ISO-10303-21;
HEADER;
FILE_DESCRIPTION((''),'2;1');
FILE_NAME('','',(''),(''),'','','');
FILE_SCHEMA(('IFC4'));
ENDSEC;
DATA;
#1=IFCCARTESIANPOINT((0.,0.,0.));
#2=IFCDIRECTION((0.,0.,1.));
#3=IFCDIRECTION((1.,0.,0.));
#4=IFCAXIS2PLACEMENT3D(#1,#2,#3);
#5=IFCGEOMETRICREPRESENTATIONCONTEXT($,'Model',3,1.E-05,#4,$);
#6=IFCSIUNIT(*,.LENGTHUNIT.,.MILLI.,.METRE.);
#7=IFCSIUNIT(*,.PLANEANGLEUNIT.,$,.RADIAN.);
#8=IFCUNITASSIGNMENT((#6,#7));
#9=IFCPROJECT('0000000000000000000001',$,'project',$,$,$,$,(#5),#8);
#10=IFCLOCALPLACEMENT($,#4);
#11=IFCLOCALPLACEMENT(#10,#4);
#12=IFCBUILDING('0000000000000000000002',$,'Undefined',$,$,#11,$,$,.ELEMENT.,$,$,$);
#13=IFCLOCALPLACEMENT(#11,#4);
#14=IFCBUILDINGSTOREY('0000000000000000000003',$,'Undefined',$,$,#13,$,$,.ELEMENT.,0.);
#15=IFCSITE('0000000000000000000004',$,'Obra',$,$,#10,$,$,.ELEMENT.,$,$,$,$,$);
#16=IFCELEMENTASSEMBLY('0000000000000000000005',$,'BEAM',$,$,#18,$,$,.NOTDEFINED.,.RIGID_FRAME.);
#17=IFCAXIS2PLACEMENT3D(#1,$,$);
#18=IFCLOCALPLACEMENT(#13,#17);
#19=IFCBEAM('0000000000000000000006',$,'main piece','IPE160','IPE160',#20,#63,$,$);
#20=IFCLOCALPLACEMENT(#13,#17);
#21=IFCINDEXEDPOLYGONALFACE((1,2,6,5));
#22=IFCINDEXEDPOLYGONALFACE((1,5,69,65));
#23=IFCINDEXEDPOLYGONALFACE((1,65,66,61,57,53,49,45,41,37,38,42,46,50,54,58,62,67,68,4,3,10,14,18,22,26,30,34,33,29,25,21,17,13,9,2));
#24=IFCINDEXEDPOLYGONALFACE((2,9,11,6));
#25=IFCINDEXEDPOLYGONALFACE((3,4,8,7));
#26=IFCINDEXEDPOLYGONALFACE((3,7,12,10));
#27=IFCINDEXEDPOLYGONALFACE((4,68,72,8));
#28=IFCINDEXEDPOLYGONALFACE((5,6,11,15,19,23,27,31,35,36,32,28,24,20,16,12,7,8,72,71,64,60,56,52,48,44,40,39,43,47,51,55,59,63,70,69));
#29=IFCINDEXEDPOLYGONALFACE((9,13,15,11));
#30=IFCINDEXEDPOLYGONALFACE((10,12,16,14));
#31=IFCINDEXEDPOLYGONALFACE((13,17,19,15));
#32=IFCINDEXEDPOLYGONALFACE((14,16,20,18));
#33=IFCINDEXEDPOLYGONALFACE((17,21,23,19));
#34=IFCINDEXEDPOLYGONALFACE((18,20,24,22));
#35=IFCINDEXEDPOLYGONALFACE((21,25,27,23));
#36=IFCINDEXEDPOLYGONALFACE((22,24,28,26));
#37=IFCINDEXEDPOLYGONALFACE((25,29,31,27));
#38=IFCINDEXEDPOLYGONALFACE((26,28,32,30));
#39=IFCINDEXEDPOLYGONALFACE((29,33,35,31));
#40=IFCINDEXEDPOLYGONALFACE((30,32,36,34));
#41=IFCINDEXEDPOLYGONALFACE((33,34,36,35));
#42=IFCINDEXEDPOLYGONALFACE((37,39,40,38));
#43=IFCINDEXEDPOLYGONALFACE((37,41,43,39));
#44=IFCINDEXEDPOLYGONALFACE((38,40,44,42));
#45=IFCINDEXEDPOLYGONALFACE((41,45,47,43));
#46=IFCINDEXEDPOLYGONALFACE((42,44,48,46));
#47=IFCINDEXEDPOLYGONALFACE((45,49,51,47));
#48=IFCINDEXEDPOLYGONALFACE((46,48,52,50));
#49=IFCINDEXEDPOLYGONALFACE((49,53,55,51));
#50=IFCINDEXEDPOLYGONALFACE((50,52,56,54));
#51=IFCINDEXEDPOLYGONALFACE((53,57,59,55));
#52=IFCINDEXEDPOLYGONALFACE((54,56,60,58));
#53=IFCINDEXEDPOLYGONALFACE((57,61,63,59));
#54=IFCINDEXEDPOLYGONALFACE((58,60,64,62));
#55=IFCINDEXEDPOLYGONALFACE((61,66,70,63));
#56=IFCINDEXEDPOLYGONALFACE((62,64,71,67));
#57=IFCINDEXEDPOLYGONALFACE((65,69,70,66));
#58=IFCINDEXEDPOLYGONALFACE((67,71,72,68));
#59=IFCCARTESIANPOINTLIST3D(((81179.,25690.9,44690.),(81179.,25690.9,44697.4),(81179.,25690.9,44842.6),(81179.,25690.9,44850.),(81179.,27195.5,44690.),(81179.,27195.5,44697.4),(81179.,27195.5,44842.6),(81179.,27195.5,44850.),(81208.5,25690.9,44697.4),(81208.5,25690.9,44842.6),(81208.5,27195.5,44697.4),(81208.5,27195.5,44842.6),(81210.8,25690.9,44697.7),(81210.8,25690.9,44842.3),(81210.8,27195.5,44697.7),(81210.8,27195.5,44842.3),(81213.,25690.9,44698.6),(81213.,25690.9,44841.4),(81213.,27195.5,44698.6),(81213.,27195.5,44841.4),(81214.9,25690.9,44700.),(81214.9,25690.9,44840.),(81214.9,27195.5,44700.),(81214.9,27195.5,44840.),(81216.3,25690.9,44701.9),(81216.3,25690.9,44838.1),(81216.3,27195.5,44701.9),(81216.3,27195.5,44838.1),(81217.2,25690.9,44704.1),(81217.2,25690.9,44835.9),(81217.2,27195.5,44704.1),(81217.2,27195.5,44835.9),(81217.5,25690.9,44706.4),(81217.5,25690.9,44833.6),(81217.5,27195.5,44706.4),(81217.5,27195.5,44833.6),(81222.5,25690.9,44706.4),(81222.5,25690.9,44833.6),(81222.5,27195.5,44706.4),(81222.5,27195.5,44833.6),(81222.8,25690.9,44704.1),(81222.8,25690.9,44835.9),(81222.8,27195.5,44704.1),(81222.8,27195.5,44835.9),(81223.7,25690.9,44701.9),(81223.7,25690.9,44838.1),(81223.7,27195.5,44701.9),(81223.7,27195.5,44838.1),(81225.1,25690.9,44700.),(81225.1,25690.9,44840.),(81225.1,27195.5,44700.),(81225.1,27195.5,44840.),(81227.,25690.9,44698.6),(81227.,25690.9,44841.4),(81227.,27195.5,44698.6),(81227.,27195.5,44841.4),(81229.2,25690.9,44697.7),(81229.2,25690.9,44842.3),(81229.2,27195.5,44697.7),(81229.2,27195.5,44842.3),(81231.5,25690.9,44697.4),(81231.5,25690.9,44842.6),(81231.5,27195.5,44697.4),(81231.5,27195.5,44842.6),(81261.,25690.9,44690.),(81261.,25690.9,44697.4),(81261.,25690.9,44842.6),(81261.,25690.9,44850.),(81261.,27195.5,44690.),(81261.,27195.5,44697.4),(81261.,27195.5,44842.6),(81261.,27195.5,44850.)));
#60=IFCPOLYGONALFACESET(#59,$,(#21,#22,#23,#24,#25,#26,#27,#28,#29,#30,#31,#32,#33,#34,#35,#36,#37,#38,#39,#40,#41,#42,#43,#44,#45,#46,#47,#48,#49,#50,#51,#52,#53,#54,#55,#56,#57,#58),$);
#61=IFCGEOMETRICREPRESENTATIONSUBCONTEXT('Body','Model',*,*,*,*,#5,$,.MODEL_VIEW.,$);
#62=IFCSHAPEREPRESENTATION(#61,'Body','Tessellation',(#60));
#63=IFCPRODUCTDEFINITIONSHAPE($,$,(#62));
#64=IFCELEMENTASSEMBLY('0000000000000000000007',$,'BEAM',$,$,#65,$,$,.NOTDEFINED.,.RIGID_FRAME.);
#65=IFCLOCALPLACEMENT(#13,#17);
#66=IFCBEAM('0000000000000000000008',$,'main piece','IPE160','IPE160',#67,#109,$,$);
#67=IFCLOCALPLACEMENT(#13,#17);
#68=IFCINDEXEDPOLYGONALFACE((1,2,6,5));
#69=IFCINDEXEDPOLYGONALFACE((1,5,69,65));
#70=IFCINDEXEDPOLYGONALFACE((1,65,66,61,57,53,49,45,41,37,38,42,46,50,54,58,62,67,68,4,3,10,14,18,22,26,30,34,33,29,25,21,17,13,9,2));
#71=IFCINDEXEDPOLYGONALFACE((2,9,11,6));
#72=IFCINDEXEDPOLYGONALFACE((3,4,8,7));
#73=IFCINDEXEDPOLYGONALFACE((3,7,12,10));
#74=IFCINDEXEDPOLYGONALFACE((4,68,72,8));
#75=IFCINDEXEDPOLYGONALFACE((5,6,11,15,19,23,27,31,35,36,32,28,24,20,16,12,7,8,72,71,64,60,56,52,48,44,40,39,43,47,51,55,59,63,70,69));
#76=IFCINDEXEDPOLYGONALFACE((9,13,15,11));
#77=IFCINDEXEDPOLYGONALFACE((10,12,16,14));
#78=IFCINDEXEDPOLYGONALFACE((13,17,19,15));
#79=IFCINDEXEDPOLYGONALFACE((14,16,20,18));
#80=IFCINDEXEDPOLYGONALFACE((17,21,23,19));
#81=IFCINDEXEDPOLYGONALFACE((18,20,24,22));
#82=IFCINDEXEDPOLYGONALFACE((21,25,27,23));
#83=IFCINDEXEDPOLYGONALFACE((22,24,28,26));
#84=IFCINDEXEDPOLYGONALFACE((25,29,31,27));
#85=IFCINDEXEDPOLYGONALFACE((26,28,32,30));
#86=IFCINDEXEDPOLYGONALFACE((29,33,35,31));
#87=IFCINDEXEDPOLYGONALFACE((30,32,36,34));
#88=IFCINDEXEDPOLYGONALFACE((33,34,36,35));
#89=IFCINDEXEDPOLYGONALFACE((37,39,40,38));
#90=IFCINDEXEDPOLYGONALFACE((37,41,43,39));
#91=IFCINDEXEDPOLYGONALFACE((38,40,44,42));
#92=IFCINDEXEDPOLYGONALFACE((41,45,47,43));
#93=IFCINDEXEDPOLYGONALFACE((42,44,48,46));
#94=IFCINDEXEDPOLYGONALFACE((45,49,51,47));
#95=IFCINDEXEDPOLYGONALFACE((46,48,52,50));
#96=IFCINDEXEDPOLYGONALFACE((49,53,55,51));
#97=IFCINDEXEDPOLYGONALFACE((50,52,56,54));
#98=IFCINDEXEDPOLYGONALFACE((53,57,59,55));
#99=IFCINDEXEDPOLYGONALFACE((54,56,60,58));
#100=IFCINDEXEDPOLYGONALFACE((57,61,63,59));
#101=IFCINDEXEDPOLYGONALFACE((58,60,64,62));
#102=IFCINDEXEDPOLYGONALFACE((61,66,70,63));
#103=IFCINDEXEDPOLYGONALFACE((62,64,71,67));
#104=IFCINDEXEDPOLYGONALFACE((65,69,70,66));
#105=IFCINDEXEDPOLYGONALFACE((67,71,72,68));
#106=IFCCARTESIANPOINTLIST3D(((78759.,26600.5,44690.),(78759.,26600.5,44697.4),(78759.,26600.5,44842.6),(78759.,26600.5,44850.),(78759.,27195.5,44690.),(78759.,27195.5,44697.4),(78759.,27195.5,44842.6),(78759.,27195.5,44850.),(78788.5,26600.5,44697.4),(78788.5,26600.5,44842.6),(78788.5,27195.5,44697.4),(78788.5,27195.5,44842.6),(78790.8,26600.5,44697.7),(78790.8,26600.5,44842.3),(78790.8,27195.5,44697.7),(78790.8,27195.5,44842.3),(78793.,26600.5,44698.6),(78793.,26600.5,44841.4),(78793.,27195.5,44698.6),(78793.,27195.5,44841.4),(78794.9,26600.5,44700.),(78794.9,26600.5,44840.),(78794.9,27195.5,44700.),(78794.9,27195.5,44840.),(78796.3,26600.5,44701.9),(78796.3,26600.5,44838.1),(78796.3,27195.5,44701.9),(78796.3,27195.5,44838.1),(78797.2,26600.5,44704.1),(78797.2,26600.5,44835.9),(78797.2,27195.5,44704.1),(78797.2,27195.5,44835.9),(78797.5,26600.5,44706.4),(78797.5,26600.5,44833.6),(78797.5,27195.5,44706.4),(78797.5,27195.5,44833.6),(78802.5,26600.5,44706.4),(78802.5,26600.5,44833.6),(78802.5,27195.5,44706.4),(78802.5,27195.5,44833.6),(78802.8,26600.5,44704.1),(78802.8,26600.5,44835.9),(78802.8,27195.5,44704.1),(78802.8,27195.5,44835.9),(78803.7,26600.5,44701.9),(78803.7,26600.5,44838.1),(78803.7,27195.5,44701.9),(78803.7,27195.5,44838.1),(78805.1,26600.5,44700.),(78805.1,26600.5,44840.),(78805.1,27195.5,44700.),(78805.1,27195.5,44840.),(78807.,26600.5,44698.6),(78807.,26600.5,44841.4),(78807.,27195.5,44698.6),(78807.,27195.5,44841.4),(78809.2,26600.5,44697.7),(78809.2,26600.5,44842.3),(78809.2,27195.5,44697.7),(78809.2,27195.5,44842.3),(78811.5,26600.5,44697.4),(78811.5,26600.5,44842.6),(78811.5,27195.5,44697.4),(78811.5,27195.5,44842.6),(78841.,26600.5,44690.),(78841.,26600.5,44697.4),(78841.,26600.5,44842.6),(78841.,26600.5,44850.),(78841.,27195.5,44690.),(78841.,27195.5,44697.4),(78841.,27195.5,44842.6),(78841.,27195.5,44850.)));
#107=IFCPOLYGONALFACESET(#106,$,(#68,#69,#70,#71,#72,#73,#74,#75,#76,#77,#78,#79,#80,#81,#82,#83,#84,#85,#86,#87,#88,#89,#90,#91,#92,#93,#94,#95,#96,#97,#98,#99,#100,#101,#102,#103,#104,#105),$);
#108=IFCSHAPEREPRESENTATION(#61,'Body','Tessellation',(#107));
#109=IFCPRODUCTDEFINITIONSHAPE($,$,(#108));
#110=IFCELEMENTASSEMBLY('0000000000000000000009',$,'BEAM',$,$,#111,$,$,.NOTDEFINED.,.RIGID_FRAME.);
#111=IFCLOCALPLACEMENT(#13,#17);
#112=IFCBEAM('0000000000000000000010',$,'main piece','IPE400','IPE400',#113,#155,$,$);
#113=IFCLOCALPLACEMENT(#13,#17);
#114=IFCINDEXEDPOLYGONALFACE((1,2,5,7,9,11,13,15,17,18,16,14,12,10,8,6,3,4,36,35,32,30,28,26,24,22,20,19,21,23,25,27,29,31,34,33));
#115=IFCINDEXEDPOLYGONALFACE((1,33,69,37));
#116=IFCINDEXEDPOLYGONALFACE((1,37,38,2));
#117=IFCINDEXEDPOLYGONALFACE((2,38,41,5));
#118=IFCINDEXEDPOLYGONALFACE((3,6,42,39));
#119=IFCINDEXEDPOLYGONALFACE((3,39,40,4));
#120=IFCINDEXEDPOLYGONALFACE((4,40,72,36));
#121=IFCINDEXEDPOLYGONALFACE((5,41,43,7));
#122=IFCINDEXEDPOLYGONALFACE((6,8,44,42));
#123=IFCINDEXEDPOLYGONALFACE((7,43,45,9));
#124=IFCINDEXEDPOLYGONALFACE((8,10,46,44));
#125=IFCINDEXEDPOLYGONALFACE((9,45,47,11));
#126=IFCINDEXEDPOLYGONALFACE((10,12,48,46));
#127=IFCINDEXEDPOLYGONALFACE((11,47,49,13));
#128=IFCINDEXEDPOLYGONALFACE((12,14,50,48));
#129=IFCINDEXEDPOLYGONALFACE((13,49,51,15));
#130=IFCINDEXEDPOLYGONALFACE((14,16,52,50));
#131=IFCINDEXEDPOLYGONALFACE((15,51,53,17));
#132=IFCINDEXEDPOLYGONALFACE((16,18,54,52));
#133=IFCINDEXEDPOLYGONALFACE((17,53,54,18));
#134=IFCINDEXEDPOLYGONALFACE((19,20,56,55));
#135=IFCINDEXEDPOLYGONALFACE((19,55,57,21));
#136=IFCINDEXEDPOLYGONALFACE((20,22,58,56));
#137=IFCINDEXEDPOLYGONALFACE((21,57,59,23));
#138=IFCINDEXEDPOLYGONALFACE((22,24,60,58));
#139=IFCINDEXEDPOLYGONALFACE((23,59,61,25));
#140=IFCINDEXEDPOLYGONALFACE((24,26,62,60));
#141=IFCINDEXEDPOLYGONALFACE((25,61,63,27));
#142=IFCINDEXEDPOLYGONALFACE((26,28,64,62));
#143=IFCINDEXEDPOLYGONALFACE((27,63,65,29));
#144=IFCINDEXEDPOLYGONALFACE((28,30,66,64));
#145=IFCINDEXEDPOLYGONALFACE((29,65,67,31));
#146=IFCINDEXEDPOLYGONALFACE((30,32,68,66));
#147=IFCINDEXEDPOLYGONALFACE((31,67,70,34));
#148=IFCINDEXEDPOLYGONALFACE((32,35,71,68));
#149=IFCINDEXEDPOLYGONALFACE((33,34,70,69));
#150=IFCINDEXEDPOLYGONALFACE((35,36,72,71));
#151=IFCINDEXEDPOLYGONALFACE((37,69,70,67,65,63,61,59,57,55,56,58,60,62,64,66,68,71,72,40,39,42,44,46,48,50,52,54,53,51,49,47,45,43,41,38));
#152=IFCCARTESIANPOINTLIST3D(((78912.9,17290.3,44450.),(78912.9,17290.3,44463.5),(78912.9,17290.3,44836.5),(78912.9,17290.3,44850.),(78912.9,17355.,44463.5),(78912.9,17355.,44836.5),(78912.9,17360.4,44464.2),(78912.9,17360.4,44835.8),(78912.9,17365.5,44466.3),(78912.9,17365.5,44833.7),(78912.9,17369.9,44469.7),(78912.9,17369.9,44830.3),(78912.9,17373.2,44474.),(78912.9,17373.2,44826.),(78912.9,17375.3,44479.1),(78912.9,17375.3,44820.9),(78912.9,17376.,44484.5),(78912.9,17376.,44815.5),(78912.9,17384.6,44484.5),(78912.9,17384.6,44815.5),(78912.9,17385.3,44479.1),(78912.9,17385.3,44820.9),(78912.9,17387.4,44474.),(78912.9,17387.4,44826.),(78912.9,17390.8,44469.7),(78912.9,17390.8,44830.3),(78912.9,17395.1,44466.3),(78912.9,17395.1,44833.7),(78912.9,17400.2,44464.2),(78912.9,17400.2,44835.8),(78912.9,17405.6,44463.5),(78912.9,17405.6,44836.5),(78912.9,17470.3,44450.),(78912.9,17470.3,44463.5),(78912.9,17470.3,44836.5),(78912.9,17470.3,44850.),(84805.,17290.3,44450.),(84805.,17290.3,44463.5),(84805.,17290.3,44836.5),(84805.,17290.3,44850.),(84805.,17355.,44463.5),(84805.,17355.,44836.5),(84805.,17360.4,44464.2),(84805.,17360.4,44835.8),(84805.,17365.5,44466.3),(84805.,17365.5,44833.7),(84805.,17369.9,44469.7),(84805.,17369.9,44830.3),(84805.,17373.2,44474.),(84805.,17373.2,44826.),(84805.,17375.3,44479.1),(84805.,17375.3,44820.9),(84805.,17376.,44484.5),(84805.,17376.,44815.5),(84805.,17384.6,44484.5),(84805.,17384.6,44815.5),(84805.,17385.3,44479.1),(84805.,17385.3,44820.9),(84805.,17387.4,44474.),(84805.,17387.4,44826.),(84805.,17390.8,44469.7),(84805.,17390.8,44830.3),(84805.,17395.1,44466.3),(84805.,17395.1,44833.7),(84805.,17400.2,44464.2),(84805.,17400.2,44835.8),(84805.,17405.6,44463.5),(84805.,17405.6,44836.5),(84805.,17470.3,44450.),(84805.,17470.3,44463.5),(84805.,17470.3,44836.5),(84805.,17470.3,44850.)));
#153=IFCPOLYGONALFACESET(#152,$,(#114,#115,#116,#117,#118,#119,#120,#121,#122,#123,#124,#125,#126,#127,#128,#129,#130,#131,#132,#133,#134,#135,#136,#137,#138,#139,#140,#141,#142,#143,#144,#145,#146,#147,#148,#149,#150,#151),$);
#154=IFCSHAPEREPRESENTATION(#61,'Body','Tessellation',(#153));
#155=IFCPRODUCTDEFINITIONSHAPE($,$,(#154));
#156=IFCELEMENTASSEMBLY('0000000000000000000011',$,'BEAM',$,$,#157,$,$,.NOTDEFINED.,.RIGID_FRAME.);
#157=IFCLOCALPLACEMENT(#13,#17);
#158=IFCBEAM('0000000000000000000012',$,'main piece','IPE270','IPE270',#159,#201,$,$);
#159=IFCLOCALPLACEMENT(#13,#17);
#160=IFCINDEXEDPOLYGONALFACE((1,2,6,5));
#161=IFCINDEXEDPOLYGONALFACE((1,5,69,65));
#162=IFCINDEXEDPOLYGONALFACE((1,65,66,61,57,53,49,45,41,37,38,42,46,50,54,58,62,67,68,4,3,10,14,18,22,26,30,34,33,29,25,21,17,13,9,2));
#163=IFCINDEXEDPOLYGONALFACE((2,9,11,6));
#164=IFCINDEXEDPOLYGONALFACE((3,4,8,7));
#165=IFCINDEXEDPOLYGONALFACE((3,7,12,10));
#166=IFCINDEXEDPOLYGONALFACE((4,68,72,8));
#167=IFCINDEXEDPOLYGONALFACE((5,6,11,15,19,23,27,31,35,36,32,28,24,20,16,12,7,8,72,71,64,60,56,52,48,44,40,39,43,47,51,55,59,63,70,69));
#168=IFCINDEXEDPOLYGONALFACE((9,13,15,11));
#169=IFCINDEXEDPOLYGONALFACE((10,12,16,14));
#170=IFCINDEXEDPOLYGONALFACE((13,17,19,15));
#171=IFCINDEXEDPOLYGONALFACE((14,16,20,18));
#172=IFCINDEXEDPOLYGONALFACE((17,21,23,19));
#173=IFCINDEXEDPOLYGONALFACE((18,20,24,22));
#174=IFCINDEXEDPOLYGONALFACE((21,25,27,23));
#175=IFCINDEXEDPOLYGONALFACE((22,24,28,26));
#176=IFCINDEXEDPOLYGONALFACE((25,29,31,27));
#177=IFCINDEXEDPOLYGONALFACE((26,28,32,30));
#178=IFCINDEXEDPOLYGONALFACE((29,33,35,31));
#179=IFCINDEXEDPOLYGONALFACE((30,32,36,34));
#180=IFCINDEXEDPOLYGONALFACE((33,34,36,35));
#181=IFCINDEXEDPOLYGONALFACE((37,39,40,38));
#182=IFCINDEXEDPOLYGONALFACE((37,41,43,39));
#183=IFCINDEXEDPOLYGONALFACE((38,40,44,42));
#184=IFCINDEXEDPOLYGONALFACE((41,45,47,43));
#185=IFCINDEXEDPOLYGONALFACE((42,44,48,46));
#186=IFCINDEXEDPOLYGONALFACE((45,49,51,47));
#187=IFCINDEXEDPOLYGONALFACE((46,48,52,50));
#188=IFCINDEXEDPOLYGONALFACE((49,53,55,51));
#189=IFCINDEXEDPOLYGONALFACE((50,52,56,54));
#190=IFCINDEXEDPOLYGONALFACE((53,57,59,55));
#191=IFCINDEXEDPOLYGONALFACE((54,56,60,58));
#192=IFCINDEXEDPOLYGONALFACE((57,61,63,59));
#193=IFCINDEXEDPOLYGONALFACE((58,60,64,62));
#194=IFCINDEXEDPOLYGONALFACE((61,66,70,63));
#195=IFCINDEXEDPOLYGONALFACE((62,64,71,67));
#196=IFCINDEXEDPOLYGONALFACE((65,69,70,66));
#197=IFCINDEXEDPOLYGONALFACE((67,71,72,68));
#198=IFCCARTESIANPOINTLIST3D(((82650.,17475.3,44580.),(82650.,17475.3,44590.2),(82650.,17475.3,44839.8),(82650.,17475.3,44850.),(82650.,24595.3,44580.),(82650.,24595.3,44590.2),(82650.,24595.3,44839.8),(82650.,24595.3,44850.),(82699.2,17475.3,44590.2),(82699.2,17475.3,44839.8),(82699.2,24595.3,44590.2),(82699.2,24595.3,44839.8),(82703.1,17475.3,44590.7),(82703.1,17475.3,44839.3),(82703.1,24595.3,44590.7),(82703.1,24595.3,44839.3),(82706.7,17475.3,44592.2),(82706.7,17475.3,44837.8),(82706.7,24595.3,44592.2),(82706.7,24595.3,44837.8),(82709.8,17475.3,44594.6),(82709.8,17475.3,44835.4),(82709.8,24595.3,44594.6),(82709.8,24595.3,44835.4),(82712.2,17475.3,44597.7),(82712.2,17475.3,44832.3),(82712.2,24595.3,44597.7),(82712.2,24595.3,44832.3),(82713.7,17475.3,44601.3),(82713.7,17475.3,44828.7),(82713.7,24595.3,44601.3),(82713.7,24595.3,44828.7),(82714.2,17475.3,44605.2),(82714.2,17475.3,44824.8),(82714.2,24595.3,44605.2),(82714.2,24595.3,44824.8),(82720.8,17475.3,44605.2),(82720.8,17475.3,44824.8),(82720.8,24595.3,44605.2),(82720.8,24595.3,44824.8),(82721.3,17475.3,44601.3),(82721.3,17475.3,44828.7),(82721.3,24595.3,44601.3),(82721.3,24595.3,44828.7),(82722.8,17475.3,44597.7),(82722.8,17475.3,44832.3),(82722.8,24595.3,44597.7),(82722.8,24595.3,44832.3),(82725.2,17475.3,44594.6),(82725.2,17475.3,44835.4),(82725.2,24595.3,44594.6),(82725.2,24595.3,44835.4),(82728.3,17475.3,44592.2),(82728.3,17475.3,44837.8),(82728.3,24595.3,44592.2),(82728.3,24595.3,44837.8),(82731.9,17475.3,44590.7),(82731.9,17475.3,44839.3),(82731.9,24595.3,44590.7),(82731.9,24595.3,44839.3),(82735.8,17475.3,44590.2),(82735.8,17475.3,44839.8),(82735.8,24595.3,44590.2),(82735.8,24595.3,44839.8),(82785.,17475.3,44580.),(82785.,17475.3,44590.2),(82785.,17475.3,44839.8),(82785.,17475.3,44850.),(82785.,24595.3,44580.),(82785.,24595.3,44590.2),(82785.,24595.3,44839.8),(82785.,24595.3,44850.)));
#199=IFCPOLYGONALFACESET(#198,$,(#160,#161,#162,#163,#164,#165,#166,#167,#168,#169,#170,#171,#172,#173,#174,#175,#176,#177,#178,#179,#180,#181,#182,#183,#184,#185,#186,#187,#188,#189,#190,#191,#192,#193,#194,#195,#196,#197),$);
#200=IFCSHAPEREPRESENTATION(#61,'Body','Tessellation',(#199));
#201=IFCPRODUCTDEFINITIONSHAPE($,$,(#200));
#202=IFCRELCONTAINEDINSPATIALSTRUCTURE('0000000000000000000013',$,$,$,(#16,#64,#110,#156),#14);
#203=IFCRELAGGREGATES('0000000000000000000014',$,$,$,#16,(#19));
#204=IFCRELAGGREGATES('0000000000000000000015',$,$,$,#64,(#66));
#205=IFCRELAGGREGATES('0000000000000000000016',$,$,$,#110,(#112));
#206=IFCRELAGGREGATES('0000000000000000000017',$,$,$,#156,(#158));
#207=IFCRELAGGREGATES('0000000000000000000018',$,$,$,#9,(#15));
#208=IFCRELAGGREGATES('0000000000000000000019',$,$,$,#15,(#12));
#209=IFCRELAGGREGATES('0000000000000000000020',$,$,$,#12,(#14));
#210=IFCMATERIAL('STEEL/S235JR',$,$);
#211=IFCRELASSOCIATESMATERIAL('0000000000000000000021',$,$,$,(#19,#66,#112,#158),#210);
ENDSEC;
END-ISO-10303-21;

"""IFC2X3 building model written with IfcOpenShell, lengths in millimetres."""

from ifc_helpers import new_model, si_unit, frame, origin_with_axes, origin_2d_with_axis, place, context, subcontext, project, spatial, i_section, extrude, material, element, aggregate, save


model = new_model("IFC2X3")

# Units and contexts
model_context = context("Model", 3, precision=1e-05, world=origin_with_axes())
body_context = subcontext(model_context, "Body", "Model", "MODEL_VIEW")
ifc_project = project(units=[si_unit("LENGTHUNIT", "METRE", prefix="MILLI"), si_unit("PLANEANGLEUNIT", "RADIAN")], contexts=[model_context])

# Site, building, storey
site_placement = place(None, origin_with_axes())
site = spatial("IfcSite", under=ifc_project, at=site_placement, Name="Obra", CompositionType="ELEMENT")
building_placement = place(site_placement, origin_with_axes())
building = spatial("IfcBuilding", under=site, at=building_placement, Name="Undefined", CompositionType="ELEMENT")
storey_placement = place(building_placement, origin_with_axes())
storey = spatial("IfcBuildingStorey", under=building, at=storey_placement, Name="Undefined", CompositionType="ELEMENT", Elevation=0.0)

# Shared definitions
ifc_material = material(Name="STEEL/S235JR")

# Element assemblies, beams
assembly_1_placement = place(storey_placement, origin_with_axes())
assembly_1 = element("IfcElementAssembly", 1, at=assembly_1_placement, inside=storey, Name="BEAM", AssemblyPlace="NOTDEFINED", PredefinedType="RIGID_FRAME")
beam_1_placement = place(assembly_1_placement, frame((81220.0, 25690.9, 44770.0), z_axis=(0.0, 0.0, 1.0), x_axis=(-0.000002, 1.0, 0.0)))
beam_1 = element("IfcBeam", 2, at=beam_1_placement, material=ifc_material, Name="main piece", Description="IPE160", ObjectType="IPE160", context=body_context, shape_type="SweptSolid", body=[
    extrude(i_section(OverallWidth=82.0, OverallDepth=160.0, WebThickness=5.0, FlangeThickness=7.4, FilletRadius=9.0, at=origin_2d_with_axis()), frame((1504.6, 0.0, 0.0), z_axis=(-1.0, 0.0, 0.0), x_axis=(0.0, -1.0, 0.0)), (0.0, 0.0, 1.0), 1504.6),
])
aggregate(assembly_1, [beam_1])
assembly_2_placement = place(storey_placement, origin_with_axes())
assembly_2 = element("IfcElementAssembly", 3, at=assembly_2_placement, inside=storey, Name="BEAM", AssemblyPlace="NOTDEFINED", PredefinedType="RIGID_FRAME")
beam_2_placement = place(assembly_2_placement, frame((78800.0, 26600.5, 44770.0), z_axis=(0.0, 0.0, 1.0), x_axis=(0.0, 1.0, 0.0)))
beam_2 = element("IfcBeam", 4, at=beam_2_placement, material=ifc_material, Name="main piece", Description="IPE160", ObjectType="IPE160", context=body_context, shape_type="SweptSolid", body=[
    extrude(i_section(OverallWidth=82.0, OverallDepth=160.0, WebThickness=5.0, FlangeThickness=7.4, FilletRadius=9.0, at=origin_2d_with_axis()), frame((595.1, 0.0, 0.0), z_axis=(-1.0, 0.0, 0.0), x_axis=(0.0, -1.0, 0.0)), (0.0, 0.0, 1.0), 595.0),
])
aggregate(assembly_2, [beam_2])
assembly_3_placement = place(storey_placement, origin_with_axes())
assembly_3 = element("IfcElementAssembly", 5, at=assembly_3_placement, inside=storey, Name="BEAM", AssemblyPlace="NOTDEFINED", PredefinedType="RIGID_FRAME")
beam_3_placement = place(assembly_3_placement, frame((78912.9, 17380.3, 44650.0), z_axis=(0.0, 0.0, 1.0), x_axis=(1.0, 0.0, 0.0)))
beam_3 = element("IfcBeam", 6, at=beam_3_placement, material=ifc_material, Name="main piece", Description="IPE400", ObjectType="IPE400", context=body_context, shape_type="SweptSolid", body=[
    extrude(i_section(OverallWidth=180.0, OverallDepth=400.0, WebThickness=8.6, FlangeThickness=13.5, FilletRadius=21.0, at=origin_2d_with_axis()), frame((5892.1, 0.0, 0.0), z_axis=(-1.0, 0.0, 0.0), x_axis=(0.0, -1.0, 0.0)), (0.0, 0.0, 1.0), 5892.1),
])
aggregate(assembly_3, [beam_3])
assembly_4_placement = place(storey_placement, origin_with_axes())
assembly_4 = element("IfcElementAssembly", 7, at=assembly_4_placement, inside=storey, Name="BEAM", AssemblyPlace="NOTDEFINED", PredefinedType="RIGID_FRAME")
beam_4_placement = place(assembly_4_placement, frame((82717.5, 17475.3, 44715.0), z_axis=(0.0, 0.0, 1.0), x_axis=(0.0, 1.0, 0.0)))
beam_4 = element("IfcBeam", 8, at=beam_4_placement, material=ifc_material, Name="main piece", Description="IPE270", ObjectType="IPE270", context=body_context, shape_type="SweptSolid", body=[
    extrude(i_section(OverallWidth=135.0, OverallDepth=270.0, WebThickness=6.6, FlangeThickness=10.2, FilletRadius=15.0, at=origin_2d_with_axis()), frame((7120.0, 0.0, 0.0), z_axis=(-1.0, 0.0, 0.0), x_axis=(0.0, -1.0, 0.0)), (0.0, 0.0, 1.0), 7120.0),
])
aggregate(assembly_4, [beam_4])

save(model, "model.ifc")
